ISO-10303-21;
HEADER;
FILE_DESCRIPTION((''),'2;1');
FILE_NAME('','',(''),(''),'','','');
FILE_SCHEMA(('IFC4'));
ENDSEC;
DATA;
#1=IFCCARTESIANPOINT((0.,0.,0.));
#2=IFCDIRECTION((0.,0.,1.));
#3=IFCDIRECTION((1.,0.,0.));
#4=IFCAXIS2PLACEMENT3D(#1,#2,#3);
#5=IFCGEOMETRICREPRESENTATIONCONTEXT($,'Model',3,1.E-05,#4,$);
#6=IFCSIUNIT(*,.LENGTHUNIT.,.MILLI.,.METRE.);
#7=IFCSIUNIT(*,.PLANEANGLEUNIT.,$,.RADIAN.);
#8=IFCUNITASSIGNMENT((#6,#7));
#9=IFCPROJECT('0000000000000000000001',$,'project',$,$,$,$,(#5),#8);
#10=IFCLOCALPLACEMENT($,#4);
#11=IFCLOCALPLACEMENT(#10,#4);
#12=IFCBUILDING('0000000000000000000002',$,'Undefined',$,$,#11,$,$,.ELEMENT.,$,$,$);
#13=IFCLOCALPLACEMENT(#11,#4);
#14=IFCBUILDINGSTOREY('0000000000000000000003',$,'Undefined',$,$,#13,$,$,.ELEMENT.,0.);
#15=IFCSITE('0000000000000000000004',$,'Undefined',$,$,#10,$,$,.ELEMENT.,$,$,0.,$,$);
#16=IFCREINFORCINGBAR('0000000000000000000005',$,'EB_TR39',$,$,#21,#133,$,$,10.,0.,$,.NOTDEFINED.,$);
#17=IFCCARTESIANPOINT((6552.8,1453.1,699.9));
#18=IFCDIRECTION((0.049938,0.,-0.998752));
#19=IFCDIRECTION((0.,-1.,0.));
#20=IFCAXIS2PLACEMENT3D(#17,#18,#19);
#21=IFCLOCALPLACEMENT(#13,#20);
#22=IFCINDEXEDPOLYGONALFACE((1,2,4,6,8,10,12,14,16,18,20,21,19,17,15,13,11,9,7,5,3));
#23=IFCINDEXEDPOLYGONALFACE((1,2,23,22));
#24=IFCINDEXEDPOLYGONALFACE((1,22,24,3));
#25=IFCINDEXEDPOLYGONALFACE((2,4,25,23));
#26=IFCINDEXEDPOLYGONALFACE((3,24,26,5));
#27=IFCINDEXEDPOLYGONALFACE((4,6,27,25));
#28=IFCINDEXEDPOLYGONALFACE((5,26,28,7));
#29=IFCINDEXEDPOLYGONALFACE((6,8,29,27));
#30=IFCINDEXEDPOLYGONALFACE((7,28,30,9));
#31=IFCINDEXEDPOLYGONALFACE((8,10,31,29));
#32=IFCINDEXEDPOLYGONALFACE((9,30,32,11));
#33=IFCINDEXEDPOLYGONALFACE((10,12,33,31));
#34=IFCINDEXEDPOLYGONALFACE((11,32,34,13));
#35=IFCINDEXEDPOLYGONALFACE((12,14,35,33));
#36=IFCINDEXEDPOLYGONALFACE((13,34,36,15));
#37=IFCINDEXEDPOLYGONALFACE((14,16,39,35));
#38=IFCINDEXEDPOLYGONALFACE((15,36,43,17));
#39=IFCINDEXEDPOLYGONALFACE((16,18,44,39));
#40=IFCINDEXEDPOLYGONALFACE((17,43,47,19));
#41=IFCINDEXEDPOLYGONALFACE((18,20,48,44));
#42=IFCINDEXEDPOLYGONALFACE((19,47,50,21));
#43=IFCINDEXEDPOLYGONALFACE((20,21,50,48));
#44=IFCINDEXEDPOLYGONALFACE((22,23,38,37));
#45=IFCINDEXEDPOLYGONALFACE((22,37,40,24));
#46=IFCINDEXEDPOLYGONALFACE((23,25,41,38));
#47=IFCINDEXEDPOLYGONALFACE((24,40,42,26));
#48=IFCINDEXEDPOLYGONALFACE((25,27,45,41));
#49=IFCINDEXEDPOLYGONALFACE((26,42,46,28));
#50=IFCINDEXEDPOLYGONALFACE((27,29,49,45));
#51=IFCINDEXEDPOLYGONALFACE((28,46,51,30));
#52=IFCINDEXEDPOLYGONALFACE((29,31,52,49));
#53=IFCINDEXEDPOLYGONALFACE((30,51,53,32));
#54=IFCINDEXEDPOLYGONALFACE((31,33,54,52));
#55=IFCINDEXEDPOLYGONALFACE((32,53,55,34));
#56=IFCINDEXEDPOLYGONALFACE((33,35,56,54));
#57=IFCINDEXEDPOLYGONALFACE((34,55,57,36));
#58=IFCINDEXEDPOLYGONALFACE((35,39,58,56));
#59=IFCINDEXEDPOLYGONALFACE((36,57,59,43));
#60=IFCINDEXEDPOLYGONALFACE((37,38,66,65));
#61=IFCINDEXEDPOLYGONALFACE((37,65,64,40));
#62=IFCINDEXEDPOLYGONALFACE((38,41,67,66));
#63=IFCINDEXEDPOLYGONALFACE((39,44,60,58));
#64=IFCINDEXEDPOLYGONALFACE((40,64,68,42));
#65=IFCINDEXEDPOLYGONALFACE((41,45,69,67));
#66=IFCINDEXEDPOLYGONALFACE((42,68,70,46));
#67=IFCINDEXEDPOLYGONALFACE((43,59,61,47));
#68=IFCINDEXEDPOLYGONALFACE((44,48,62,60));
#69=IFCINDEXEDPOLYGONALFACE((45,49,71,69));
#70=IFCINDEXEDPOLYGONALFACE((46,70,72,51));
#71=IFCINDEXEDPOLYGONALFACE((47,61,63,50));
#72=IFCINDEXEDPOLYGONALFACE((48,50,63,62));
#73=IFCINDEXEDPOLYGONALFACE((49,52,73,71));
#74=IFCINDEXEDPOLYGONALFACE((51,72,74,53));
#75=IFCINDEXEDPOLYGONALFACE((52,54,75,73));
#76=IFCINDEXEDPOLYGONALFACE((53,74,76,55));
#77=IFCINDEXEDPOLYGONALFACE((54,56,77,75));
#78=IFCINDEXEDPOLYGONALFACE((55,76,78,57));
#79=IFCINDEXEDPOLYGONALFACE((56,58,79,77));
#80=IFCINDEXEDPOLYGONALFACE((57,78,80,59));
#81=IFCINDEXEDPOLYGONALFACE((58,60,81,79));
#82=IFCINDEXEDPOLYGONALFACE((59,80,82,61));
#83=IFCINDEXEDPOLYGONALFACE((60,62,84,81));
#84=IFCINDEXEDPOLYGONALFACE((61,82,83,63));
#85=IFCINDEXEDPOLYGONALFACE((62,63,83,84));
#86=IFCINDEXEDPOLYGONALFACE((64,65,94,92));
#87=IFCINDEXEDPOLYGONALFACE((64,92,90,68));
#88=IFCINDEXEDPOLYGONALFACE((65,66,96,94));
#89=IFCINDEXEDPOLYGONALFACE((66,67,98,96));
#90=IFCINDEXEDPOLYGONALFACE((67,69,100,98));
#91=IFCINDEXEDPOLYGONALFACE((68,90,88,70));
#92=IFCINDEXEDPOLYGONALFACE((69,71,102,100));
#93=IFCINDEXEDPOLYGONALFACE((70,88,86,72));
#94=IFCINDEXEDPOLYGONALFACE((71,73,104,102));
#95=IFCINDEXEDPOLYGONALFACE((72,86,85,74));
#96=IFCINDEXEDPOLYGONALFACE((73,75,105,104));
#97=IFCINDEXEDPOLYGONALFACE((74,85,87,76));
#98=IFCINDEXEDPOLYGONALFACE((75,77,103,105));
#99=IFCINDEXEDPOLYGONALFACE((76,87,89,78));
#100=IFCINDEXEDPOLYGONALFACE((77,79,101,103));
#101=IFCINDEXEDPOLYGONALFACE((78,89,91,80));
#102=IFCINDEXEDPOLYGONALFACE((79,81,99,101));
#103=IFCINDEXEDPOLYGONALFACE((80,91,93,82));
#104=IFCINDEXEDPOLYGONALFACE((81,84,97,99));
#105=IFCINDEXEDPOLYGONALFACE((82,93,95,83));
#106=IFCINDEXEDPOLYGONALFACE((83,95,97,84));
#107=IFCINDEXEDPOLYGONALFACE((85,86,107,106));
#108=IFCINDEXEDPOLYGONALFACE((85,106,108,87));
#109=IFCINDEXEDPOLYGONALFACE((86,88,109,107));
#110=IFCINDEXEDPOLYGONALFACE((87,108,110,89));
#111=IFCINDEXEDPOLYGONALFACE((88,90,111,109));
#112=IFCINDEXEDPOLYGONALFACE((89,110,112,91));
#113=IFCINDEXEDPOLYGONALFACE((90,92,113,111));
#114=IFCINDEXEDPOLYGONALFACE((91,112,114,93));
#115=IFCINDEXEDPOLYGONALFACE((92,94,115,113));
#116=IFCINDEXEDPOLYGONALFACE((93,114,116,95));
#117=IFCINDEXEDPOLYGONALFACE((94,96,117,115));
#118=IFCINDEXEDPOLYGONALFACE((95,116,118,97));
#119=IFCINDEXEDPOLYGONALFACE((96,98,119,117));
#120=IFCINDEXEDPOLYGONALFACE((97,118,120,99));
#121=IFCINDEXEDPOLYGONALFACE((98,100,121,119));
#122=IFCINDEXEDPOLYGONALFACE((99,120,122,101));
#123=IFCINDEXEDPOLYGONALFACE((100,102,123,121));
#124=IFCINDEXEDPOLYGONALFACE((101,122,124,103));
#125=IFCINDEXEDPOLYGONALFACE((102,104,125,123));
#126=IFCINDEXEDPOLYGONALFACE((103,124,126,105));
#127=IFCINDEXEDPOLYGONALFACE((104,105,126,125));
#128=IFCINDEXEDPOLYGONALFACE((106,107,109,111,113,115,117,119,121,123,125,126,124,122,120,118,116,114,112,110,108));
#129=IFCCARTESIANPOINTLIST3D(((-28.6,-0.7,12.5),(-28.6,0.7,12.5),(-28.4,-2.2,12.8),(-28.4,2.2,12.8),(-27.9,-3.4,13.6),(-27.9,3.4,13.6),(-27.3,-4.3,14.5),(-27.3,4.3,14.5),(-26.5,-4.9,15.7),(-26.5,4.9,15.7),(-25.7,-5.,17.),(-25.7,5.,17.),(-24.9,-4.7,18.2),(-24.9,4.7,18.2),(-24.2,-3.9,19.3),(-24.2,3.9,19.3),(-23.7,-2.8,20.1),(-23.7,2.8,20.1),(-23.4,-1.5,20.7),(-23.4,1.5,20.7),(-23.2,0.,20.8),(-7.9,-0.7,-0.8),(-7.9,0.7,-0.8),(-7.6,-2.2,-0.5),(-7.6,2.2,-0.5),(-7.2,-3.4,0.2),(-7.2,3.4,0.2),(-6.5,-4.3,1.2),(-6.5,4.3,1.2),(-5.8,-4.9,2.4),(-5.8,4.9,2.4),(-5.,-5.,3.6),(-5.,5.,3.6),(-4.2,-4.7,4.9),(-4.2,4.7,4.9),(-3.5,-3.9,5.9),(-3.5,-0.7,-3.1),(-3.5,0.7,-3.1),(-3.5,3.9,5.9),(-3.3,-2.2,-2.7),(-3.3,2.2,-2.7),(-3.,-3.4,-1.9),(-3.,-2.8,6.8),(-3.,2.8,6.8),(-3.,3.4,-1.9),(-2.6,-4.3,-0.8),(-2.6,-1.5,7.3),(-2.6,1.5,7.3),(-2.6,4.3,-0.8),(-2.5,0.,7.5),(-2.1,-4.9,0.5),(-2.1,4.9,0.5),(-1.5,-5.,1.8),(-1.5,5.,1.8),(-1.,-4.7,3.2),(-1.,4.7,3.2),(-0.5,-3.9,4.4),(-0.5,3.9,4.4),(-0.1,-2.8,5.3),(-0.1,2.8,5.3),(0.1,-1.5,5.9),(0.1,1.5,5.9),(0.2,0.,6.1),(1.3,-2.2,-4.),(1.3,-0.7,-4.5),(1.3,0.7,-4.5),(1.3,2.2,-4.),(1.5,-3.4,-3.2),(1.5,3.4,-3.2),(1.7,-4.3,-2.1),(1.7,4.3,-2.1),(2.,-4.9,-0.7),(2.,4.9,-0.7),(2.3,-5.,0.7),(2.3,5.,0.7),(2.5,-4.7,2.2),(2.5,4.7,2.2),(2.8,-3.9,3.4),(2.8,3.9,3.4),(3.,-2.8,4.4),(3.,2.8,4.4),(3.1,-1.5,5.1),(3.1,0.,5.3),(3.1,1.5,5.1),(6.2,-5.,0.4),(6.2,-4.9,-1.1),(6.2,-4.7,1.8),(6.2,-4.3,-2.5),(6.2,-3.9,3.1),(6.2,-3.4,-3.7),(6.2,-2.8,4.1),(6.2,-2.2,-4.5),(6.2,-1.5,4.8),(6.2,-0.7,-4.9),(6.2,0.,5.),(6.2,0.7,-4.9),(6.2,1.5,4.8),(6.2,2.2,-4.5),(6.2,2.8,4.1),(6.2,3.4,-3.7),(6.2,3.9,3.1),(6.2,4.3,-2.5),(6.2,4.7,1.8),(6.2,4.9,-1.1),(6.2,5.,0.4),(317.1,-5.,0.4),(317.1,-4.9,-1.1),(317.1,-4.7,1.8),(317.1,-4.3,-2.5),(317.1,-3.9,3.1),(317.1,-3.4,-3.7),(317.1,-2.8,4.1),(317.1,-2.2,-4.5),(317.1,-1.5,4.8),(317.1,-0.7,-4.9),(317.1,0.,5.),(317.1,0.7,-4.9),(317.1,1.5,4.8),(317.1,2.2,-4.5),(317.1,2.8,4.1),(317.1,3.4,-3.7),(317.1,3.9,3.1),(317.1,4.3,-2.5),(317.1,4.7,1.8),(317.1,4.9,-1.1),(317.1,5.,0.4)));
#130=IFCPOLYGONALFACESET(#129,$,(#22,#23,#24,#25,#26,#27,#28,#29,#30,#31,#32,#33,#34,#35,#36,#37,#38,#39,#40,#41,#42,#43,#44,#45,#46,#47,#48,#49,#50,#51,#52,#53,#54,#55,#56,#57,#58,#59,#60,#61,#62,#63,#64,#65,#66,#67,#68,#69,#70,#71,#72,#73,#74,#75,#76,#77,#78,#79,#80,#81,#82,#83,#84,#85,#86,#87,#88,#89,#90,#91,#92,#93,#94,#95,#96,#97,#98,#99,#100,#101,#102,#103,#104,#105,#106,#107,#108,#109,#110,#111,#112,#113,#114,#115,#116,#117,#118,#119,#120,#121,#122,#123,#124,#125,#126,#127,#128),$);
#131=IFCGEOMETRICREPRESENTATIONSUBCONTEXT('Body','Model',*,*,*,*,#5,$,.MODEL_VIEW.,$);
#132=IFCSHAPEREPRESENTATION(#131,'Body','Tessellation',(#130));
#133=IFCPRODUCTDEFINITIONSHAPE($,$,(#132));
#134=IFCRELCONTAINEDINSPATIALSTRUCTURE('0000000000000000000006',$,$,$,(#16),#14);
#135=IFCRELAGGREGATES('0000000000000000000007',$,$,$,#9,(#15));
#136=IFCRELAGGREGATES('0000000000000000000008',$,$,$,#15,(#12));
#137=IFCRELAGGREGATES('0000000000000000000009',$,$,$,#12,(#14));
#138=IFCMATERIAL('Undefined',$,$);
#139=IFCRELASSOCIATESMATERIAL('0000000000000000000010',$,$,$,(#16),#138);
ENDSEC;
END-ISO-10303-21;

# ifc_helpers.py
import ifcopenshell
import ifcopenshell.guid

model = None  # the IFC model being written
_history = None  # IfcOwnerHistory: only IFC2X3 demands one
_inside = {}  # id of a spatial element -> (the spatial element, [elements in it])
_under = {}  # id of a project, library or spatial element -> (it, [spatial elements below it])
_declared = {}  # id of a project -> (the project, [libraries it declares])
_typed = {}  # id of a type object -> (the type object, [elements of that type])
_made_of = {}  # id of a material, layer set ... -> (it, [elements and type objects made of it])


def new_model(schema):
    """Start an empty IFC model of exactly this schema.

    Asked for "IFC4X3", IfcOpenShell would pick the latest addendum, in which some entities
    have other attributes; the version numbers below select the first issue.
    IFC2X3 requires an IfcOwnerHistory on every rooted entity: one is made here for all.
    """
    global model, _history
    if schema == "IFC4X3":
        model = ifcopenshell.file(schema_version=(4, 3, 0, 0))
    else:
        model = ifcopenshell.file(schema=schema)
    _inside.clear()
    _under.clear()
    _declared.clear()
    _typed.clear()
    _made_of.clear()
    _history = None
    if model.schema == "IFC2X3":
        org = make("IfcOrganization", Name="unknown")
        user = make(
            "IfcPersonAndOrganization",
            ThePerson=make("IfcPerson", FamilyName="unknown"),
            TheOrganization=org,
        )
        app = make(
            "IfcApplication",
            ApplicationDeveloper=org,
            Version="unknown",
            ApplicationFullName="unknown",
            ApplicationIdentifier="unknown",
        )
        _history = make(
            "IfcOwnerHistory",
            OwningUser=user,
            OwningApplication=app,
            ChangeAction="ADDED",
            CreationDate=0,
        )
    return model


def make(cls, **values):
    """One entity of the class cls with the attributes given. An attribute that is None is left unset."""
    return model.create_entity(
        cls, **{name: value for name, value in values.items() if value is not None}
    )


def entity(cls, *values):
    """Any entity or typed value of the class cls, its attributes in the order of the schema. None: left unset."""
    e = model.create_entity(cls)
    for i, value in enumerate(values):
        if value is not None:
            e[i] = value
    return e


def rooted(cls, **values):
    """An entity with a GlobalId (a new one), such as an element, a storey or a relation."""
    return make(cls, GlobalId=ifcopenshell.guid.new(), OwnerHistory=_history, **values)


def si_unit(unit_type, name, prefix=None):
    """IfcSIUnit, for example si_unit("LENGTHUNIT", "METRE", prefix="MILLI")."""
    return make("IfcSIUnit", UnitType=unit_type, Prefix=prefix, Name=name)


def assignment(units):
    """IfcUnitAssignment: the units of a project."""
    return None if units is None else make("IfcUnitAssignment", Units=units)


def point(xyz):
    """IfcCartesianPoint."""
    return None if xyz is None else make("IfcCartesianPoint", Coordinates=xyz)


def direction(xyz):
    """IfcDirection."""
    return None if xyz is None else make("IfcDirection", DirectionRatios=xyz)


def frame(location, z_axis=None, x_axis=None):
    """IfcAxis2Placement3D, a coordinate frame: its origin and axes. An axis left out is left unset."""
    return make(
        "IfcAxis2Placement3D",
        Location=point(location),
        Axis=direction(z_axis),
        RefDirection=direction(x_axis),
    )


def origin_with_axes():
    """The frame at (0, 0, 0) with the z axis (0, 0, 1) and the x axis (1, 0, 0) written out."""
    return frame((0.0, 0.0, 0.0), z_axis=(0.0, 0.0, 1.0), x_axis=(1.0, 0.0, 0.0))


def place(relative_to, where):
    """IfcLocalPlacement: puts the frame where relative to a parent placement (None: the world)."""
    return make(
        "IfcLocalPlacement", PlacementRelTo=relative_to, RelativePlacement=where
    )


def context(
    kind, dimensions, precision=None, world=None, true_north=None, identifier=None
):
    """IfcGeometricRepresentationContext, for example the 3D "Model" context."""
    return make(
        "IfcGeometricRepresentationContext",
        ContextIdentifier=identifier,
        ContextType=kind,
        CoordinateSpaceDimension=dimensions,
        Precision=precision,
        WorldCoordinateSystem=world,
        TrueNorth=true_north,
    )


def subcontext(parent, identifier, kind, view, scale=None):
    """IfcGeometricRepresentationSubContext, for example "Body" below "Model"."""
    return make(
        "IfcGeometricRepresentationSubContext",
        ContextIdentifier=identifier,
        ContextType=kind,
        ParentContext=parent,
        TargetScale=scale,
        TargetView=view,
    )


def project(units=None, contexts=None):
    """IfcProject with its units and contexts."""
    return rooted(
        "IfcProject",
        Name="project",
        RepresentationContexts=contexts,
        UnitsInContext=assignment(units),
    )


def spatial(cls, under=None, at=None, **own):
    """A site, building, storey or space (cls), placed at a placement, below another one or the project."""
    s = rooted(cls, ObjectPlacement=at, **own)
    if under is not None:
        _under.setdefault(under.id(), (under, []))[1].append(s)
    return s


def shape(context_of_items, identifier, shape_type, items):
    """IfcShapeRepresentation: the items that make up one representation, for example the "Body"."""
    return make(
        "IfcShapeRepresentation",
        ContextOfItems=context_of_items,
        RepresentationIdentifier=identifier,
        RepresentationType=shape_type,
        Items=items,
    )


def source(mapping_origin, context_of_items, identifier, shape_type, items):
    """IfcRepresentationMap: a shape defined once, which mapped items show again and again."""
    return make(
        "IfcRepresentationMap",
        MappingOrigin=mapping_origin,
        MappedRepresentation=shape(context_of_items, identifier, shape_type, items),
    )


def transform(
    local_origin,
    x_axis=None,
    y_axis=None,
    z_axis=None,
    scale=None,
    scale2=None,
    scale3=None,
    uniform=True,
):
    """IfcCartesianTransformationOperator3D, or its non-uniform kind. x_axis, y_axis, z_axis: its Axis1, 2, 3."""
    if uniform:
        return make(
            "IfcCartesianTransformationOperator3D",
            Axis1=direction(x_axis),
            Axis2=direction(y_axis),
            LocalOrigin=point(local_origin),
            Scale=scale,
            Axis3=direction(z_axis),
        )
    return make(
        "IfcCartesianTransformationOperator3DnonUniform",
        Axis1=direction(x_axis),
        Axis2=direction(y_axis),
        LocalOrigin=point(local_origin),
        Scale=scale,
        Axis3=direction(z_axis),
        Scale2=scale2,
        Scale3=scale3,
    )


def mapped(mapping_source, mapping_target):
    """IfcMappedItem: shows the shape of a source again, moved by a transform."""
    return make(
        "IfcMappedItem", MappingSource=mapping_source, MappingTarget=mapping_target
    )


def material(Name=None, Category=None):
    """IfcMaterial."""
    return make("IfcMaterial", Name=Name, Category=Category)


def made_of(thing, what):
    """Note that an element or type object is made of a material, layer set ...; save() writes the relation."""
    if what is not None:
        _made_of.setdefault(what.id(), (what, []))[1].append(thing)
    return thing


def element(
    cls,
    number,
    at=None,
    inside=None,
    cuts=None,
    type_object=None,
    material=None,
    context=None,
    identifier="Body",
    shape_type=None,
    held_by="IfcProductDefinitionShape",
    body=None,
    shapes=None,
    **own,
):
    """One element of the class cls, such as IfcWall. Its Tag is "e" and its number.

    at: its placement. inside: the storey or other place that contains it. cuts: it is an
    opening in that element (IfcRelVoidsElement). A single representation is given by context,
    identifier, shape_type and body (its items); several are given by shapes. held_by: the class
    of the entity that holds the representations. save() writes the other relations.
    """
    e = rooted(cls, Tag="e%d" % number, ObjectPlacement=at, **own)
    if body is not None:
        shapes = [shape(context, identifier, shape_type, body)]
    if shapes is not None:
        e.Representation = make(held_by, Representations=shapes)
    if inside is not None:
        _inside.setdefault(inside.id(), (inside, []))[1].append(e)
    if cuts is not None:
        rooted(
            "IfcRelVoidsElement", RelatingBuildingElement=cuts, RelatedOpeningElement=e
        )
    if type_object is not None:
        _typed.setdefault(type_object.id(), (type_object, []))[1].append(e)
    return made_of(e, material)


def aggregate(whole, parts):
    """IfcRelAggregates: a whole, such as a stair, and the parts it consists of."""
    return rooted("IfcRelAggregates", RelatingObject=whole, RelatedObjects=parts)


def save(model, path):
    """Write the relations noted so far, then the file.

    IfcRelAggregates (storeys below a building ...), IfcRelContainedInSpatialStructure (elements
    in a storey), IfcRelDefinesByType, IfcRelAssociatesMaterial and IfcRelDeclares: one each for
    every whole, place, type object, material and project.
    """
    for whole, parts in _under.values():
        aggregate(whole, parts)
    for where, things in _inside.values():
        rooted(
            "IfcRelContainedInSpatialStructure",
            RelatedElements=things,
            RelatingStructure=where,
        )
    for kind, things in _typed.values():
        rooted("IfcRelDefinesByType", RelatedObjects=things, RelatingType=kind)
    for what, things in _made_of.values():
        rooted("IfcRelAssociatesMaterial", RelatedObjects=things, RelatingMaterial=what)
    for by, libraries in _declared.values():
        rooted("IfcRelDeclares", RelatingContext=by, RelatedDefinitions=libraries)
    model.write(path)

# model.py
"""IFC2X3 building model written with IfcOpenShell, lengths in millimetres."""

from ifc_helpers import new_model, entity, si_unit, frame, origin_with_axes, place, context, subcontext, project, spatial, source, transform, mapped, material, element, save


model = new_model("IFC2X3")

# Units and contexts
model_context = context("Model", 3, precision=1e-05, world=origin_with_axes())
body_context = subcontext(model_context, "Body", "Model", "MODEL_VIEW")
ifc_project = project(units=[si_unit("LENGTHUNIT", "METRE", prefix="MILLI"), si_unit("PLANEANGLEUNIT", "RADIAN")], contexts=[model_context])

# Site, building, storey
site_placement = place(None, origin_with_axes())
site = spatial("IfcSite", under=ifc_project, at=site_placement, Name="Undefined", CompositionType="ELEMENT", RefElevation=0.0)
building_placement = place(site_placement, origin_with_axes())
building = spatial("IfcBuilding", under=site, at=building_placement, Name="Undefined", CompositionType="ELEMENT")
storey_placement = place(building_placement, origin_with_axes())
storey = spatial("IfcBuildingStorey", under=building, at=storey_placement, Name="Undefined", CompositionType="ELEMENT", Elevation=0.0)

# Reinforcing bar
ifc_material_1 = material(Name="Undefined")
shared_shape_1 = source(origin_with_axes(), body_context, "Body", "AdvancedSweptSolid", [
    entity("IfcSweptDiskSolid", entity("IfcCompositeCurve", [entity("IfcCompositeCurveSegment", "CONTINUOUS", True, entity("IfcTrimmedCurve", entity("IfcLine", entity("IfcCartesianPoint", [0.0, 0.0, 0.0]), entity("IfcVector", entity("IfcDirection", [0.841694, 0.0, -0.539955]), 1.0)), [entity("IfcParameterValue", 0.0)], [entity("IfcParameterValue", 24.65374)], True, "PARAMETER")), entity("IfcCompositeCurveSegment", "CONTINUOUS", True, entity("IfcTrimmedCurve", entity("IfcCircle", entity("IfcAxis2Placement3D", entity("IfcCartesianPoint", [32.1, 0.0, 4.4]), entity("IfcDirection", [0.0, -1.0, 0.0]), entity("IfcDirection", [-0.539955, 0.0, -0.841694])), 21.0), [entity("IfcParameterValue", 0.0)], [entity("IfcParameterValue", 0.570383)], True, "PARAMETER")), entity("IfcCompositeCurveSegment", "DISCONTINUOUS", True, entity("IfcTrimmedCurve", entity("IfcLine", entity("IfcCartesianPoint", [32.1, 0.0, -16.6]), entity("IfcVector", entity("IfcDirection", [1.0, 0.0, 0.0]), 1.0)), [entity("IfcParameterValue", 0.0)], [entity("IfcParameterValue", 310.940714)], True, "PARAMETER"))], False), 5.0, None, 0.0, 336.2),
])
reinforcing_bar_1_placement = place(storey_placement, frame((6552.8, 1453.1, 699.9), z_axis=(0.049938, 0.0, -0.998752), x_axis=(0.0, -1.0, 0.0)))
element("IfcReinforcingBar", 1, at=reinforcing_bar_1_placement, inside=storey, material=ifc_material_1, Name="EB_TR39", BarRole="NOTDEFINED", CrossSectionArea=0.0, NominalDiameter=10.0, context=body_context, shape_type="MappedRepresentation", body=[
    mapped(shared_shape_1, transform((-25.9, 0.0, 16.6))),
])

save(model, "model.ifc")
